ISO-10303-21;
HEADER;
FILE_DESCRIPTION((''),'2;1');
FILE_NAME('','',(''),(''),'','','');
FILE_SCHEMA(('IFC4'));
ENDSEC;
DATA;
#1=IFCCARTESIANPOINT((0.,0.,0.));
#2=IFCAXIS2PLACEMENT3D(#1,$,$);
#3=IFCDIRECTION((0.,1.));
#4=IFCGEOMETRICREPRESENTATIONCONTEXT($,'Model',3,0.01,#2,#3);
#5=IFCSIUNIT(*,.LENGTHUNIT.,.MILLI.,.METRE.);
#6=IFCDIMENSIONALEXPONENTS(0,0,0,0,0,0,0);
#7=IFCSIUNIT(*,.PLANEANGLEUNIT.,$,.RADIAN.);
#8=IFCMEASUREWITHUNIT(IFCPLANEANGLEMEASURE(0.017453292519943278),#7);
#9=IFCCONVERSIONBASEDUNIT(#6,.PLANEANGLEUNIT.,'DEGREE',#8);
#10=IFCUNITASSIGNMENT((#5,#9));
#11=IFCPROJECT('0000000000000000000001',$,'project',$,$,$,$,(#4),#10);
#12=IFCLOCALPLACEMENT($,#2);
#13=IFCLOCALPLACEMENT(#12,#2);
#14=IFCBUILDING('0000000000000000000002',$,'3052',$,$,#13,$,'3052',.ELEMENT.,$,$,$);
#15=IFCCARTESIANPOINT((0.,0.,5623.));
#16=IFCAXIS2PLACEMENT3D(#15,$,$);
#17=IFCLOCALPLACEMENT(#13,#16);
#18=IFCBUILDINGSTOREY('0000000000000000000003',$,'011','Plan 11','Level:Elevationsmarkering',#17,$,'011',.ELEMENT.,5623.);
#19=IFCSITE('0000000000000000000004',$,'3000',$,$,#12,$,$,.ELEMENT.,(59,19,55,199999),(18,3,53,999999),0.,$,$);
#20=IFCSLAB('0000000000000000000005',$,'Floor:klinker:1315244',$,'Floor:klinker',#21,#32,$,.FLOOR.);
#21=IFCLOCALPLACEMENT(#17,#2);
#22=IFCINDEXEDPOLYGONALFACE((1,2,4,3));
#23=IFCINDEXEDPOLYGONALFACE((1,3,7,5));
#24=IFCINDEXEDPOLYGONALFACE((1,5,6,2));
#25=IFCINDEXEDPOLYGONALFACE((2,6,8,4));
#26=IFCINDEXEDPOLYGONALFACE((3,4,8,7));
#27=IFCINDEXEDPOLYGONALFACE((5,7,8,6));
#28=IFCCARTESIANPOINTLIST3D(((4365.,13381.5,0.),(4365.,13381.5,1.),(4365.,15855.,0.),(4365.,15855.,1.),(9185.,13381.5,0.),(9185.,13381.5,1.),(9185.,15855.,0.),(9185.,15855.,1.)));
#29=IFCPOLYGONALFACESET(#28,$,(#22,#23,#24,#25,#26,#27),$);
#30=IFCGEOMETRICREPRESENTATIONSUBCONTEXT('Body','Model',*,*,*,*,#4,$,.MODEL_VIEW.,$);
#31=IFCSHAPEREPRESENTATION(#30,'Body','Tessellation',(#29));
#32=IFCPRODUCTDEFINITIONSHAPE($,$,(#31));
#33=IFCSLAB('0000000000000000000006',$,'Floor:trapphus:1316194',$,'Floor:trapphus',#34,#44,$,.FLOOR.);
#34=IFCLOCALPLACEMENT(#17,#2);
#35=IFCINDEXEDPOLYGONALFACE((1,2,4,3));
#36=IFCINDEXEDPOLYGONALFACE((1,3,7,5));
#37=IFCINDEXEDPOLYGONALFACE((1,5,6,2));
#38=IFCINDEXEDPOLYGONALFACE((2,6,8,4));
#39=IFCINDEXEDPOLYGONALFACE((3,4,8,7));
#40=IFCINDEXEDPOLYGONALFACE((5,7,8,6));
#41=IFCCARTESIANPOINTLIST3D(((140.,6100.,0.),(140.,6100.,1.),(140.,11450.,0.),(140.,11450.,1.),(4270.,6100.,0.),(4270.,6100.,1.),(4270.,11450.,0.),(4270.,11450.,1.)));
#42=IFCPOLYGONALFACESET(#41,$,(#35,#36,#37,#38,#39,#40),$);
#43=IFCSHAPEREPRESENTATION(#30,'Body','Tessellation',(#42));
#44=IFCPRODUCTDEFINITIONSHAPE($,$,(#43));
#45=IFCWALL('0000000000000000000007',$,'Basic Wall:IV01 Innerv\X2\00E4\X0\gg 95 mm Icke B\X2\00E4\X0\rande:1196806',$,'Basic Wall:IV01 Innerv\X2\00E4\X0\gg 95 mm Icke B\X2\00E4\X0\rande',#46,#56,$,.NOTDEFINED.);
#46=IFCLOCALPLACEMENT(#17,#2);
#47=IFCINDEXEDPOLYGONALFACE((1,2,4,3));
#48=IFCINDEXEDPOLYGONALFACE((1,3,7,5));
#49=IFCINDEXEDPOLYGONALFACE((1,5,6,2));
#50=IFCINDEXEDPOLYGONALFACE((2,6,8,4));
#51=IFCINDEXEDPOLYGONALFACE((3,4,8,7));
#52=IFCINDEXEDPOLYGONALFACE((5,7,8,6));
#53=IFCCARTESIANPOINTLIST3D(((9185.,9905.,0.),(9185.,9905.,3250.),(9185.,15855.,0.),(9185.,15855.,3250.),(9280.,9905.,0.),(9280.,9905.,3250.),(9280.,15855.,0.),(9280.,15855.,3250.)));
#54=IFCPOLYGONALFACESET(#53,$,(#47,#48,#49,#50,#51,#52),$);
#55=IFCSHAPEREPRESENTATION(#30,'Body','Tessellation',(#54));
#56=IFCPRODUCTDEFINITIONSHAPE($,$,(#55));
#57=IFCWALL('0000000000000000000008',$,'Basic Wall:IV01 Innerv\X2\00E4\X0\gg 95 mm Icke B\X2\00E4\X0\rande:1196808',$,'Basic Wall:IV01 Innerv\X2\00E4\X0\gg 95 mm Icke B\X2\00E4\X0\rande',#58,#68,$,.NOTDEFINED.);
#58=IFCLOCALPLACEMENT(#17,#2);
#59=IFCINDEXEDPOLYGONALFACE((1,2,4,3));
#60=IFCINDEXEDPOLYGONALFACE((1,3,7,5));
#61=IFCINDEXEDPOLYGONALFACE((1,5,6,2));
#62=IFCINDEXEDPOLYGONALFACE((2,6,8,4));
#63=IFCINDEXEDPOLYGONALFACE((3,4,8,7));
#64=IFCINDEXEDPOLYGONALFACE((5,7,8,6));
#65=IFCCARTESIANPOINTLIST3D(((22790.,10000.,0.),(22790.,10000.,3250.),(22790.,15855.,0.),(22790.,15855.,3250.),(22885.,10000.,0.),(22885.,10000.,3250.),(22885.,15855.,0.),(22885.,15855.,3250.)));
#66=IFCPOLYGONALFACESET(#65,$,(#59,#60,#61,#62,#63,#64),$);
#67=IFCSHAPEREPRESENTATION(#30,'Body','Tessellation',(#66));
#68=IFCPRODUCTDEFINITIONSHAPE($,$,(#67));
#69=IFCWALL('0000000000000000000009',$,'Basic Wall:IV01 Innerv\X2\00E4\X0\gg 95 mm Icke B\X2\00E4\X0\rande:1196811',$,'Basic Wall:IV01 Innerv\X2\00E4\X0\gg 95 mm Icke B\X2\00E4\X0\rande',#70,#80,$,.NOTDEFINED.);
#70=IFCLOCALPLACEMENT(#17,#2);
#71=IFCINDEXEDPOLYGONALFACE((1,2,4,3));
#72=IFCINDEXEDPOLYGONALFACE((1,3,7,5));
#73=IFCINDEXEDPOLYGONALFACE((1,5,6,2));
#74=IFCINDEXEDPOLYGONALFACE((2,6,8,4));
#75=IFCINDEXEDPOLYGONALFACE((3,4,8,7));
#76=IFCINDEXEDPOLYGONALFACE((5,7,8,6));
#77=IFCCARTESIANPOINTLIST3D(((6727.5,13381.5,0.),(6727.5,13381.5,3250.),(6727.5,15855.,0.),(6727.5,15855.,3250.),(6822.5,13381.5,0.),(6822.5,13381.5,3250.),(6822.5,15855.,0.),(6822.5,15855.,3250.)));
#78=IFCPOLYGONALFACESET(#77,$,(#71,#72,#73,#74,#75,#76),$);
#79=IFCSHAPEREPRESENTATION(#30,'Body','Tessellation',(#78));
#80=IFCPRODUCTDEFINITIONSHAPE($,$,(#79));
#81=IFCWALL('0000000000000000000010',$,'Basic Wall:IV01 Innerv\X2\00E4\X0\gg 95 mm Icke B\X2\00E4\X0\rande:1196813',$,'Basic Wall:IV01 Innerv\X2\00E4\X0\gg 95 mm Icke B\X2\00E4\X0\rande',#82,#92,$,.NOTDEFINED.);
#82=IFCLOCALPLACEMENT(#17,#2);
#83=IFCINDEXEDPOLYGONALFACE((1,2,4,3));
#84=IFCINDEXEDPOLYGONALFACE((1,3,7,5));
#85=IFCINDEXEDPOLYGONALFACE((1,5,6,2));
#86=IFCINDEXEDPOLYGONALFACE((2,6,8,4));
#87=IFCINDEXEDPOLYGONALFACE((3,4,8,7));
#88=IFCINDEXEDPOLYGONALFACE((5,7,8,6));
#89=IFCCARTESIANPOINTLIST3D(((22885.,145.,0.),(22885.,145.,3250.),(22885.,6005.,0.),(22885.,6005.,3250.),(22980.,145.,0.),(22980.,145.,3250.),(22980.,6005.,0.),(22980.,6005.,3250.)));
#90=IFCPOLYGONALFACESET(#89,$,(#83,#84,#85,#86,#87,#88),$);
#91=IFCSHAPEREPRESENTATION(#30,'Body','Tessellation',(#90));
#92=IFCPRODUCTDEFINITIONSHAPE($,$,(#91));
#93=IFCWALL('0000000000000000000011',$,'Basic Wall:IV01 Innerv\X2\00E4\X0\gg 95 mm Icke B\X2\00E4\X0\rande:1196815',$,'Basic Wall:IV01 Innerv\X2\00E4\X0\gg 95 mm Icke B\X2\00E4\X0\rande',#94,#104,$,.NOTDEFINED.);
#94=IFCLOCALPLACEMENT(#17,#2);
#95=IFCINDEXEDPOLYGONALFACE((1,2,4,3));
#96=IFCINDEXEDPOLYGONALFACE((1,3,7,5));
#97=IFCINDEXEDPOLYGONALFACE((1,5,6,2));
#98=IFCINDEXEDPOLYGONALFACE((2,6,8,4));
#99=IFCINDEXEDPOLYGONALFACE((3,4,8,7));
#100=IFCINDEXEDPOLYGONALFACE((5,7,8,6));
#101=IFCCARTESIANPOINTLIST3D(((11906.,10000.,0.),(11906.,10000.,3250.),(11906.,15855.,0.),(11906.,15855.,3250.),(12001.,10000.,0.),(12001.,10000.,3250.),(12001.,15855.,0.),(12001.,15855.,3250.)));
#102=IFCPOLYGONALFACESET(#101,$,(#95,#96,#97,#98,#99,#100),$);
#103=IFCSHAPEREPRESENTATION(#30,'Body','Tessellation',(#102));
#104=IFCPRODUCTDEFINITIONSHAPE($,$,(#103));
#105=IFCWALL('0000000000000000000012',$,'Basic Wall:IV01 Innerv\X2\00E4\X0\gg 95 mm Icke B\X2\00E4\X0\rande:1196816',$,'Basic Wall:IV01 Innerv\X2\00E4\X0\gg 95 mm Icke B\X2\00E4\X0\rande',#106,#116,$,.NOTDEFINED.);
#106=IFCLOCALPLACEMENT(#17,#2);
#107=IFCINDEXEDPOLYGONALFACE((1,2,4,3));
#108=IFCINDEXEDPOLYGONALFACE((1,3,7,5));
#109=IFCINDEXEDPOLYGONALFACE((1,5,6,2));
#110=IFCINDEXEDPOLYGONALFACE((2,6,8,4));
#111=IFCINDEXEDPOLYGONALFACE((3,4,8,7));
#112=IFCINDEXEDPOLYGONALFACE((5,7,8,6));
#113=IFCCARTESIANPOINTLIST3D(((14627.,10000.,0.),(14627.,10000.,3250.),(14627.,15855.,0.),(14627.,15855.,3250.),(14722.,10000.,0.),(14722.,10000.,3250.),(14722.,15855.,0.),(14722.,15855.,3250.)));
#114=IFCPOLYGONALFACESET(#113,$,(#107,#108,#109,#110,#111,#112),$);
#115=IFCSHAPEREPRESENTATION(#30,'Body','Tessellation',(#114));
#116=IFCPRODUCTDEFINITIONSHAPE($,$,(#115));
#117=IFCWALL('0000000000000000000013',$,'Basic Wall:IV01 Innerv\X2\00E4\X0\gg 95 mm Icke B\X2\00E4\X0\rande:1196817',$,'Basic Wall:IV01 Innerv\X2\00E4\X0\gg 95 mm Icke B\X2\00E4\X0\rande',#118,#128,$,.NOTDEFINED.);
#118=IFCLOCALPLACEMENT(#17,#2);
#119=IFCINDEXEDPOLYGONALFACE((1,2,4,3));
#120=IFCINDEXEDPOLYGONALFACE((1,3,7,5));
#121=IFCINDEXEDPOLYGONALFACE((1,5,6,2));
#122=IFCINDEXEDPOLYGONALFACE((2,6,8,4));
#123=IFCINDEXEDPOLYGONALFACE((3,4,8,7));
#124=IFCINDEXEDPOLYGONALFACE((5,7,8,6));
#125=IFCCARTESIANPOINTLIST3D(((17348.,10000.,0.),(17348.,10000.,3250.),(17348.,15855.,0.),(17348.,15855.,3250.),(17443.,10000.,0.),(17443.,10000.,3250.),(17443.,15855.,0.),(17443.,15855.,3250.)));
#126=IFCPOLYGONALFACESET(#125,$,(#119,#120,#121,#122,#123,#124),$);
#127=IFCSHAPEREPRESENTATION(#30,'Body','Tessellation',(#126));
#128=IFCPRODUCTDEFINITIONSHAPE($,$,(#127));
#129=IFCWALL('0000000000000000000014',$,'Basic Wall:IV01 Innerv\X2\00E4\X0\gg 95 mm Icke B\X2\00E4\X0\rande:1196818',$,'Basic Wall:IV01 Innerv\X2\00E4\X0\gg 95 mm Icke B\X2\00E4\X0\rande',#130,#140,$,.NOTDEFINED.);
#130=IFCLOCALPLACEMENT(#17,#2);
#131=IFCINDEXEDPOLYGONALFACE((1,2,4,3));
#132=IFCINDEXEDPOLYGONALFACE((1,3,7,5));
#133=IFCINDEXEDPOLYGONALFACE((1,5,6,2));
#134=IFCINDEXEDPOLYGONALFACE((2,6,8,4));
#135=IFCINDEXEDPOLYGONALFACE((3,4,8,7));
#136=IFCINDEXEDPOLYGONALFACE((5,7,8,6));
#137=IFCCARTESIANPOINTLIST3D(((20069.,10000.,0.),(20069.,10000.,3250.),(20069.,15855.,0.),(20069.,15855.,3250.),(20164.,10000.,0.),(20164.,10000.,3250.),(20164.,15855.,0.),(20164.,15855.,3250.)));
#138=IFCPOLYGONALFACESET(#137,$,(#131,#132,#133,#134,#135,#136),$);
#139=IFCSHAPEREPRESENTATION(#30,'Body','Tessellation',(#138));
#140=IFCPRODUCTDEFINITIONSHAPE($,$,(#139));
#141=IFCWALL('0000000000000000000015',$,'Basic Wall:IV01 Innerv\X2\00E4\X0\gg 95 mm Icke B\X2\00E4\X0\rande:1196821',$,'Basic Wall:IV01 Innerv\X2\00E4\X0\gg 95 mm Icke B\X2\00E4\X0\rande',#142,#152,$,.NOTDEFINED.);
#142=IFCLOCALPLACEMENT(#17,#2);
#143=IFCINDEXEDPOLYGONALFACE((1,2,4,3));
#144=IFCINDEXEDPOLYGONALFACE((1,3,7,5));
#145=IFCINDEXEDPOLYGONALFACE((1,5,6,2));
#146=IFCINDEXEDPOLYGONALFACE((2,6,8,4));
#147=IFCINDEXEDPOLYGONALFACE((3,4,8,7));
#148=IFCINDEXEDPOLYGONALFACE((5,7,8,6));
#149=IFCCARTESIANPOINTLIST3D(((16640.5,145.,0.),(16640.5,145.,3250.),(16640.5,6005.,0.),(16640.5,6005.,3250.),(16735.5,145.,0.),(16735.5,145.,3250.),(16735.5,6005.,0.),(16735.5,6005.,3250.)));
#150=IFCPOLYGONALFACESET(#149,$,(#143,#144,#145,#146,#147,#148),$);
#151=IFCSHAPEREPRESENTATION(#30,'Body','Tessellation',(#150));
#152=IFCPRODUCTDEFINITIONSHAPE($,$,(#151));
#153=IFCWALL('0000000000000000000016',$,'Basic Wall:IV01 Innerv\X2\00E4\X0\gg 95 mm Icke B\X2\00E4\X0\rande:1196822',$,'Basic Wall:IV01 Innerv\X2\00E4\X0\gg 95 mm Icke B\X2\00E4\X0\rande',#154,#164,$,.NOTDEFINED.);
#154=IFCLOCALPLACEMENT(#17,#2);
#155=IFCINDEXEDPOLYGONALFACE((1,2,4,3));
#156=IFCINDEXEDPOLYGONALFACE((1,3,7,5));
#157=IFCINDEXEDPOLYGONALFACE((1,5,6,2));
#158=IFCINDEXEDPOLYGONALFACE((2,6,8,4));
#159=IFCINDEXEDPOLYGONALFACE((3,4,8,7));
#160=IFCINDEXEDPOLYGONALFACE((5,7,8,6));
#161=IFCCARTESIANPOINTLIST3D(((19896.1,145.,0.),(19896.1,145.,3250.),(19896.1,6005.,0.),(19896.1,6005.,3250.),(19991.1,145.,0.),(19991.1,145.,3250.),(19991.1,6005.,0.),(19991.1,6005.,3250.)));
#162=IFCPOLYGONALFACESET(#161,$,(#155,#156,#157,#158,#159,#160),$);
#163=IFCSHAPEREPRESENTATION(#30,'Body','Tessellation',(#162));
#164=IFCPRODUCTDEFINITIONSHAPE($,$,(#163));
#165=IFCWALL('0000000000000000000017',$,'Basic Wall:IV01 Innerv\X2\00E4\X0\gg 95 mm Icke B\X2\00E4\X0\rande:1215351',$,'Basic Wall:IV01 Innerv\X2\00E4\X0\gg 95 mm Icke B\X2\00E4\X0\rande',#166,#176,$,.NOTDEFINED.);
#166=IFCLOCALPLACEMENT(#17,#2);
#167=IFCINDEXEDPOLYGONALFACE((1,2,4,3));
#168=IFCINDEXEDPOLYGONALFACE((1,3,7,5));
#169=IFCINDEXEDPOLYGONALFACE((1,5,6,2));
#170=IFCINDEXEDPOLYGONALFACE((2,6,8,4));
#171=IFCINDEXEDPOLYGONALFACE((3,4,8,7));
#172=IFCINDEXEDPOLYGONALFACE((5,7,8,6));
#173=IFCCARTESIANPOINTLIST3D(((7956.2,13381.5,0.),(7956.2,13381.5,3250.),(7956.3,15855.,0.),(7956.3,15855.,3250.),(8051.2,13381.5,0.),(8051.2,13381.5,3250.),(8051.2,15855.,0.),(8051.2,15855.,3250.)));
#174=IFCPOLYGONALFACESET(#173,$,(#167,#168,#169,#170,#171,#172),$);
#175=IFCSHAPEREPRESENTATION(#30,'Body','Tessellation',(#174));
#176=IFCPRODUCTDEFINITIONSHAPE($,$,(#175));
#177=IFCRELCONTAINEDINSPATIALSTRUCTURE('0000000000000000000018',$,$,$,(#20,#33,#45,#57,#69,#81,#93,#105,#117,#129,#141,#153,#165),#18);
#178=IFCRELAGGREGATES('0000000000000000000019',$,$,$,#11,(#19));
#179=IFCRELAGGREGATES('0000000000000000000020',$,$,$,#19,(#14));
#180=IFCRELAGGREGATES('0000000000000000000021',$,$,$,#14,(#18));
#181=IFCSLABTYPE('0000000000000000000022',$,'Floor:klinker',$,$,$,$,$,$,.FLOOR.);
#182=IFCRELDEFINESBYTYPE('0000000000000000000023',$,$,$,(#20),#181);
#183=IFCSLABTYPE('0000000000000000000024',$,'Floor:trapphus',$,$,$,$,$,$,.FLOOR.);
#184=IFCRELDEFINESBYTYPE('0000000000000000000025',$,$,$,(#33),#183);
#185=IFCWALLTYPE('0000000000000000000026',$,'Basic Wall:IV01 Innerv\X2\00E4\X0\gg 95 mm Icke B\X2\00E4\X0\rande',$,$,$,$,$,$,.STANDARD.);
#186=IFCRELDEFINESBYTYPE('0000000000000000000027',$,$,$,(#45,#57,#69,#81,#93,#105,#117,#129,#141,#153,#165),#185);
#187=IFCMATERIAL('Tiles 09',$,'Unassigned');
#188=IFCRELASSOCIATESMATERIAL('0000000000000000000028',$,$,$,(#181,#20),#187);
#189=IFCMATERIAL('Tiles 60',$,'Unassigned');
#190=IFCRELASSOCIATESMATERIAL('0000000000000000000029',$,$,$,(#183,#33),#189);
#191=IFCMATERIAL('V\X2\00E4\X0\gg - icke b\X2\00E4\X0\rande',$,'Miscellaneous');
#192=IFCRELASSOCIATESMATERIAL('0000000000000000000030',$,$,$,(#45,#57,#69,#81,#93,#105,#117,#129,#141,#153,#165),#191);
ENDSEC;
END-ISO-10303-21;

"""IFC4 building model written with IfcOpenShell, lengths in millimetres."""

from ifc_helpers import new_model, entity, si_unit, converted_unit, direction, frame, origin, place, context, subcontext, project, spatial, indexed_curve, outline, extrude, material, type_object, element, save


model = new_model("IFC4")

# Units and contexts
model_context = context("Model", 3, precision=0.01, world=origin(), true_north=direction((0.0, 1.0)))
body_context = subcontext(model_context, "Body", "Model", "MODEL_VIEW")
ifc_project = project(units=[si_unit("LENGTHUNIT", "METRE", prefix="MILLI"), converted_unit("PLANEANGLEUNIT", "DEGREE", entity("IfcPlaneAngleMeasure", 0.017453292519943278), si_unit("PLANEANGLEUNIT", "RADIAN"), dimensions=[0, 0, 0, 0, 0, 0, 0])], contexts=[model_context])

# Site, building, storey
site_placement = place(None, origin())
site = spatial("IfcSite", under=ifc_project, at=site_placement, Name="3000", CompositionType="ELEMENT", RefLatitude=(59, 19, 55, 199999), RefLongitude=(18, 3, 53, 999999), RefElevation=0.0)
building_placement = place(site_placement, origin())
building = spatial("IfcBuilding", under=site, at=building_placement, Name="3052", LongName="3052", CompositionType="ELEMENT")
storey_placement = place(building_placement, frame((0.0, 0.0, 5623.0)))
storey = spatial("IfcBuildingStorey", under=building, at=storey_placement, Name="011", Description="Plan 11", ObjectType="Level:Elevationsmarkering", LongName="011", CompositionType="ELEMENT", Elevation=5623.0)

# Slabs
ifc_material_1 = material(Name="Tiles 09", Category="Unassigned")
slab_type_1 = type_object("IfcSlabType", Name="Floor:klinker", PredefinedType="FLOOR", material=ifc_material_1)
slab_1_placement = place(storey_placement, origin())
element("IfcSlab", 1, at=slab_1_placement, inside=storey, type_object=slab_type_1, material=ifc_material_1, Name="Floor:klinker:1315244", ObjectType="Floor:klinker", PredefinedType="FLOOR", context=body_context, shape_type="SweptSolid", body=[
    extrude(outline(indexed_curve([(-1236.8, -2410.0), (1236.8, -2410.0), (1236.8, 2410.0), (-1236.8, 2410.0), (-1236.8, -2410.0)], self_intersect=False)), frame((6775.0, 14618.3, 1.0), z_axis=(0.0, 0.0, -1.0), x_axis=(0.0, 1.0, 0.0)), (0.0, 0.0, 1.0), 1.0),
])
ifc_material_2 = material(Name="Tiles 60", Category="Unassigned")
slab_type_2 = type_object("IfcSlabType", Name="Floor:trapphus", PredefinedType="FLOOR", material=ifc_material_2)
slab_2_placement = place(storey_placement, origin())
element("IfcSlab", 2, at=slab_2_placement, inside=storey, type_object=slab_type_2, material=ifc_material_2, Name="Floor:trapphus:1316194", ObjectType="Floor:trapphus", PredefinedType="FLOOR", context=body_context, shape_type="SweptSolid", body=[
    extrude(outline(indexed_curve([(-2675.0, -2065.0), (2675.0, -2065.0), (2675.0, 2065.0), (-2675.0, 2065.0), (-2675.0, -2065.0)], self_intersect=False)), frame((2205.0, 8775.0, 1.0), z_axis=(0.0, 0.0, -1.0), x_axis=(0.0, 1.0, 0.0)), (0.0, 0.0, 1.0), 1.0),
])

# Walls
ifc_material_3 = material(Name="Vägg - icke bärande", Category="Miscellaneous")
wall_type_1 = type_object("IfcWallType", Name="Basic Wall:IV01 Innervägg 95 mm Icke Bärande", PredefinedType="STANDARD")
wall_1_placement = place(storey_placement, frame((9232.5, 15855.0, 0.0), z_axis=(0.0, 0.0, 1.0), x_axis=(0.0, -1.0, 0.0)))
element("IfcWall", 3, at=wall_1_placement, inside=storey, type_object=wall_type_1, material=ifc_material_3, Name="Basic Wall:IV01 Innervägg 95 mm Icke Bärande:1196806", ObjectType="Basic Wall:IV01 Innervägg 95 mm Icke Bärande", PredefinedType="NOTDEFINED", context=body_context, shape_type="SweptSolid", body=[
    extrude(outline(indexed_curve([(5950.0, 47.5), (0.0, 47.5), (0.0, -47.5), (5950.0, -47.5), (5950.0, 47.5)], self_intersect=False)), origin(), (0.0, 0.0, 1.0), 3250.0),
])
wall_2_placement = place(storey_placement, frame((22837.5, 10000.0, 0.0), z_axis=(0.0, 0.0, 1.0), x_axis=(0.0, 1.0, 0.0)))
element("IfcWall", 4, at=wall_2_placement, inside=storey, type_object=wall_type_1, material=ifc_material_3, Name="Basic Wall:IV01 Innervägg 95 mm Icke Bärande:1196808", ObjectType="Basic Wall:IV01 Innervägg 95 mm Icke Bärande", PredefinedType="NOTDEFINED", context=body_context, shape_type="SweptSolid", body=[
    extrude(outline(indexed_curve([(5855.0, 47.5), (0.0, 47.5), (0.0, -47.5), (5855.0, -47.5), (5855.0, 47.5)], self_intersect=False)), origin(), (0.0, 0.0, 1.0), 3250.0),
])
wall_3_placement = place(storey_placement, frame((6775.0, 13381.5, 0.0), z_axis=(0.0, 0.0, 1.0), x_axis=(0.0, 1.0, 0.0)))
element("IfcWall", 5, at=wall_3_placement, inside=storey, type_object=wall_type_1, material=ifc_material_3, Name="Basic Wall:IV01 Innervägg 95 mm Icke Bärande:1196811", ObjectType="Basic Wall:IV01 Innervägg 95 mm Icke Bärande", PredefinedType="NOTDEFINED", context=body_context, shape_type="SweptSolid", body=[
    extrude(outline(indexed_curve([(2473.5, 47.5), (0.0, 47.5), (0.0, -47.5), (2473.5, -47.5), (2473.5, 47.5)], self_intersect=False)), origin(), (0.0, 0.0, 1.0), 3250.0),
])
wall_4_placement = place(storey_placement, frame((22932.5, 6005.0, 0.0), z_axis=(0.0, 0.0, 1.0), x_axis=(0.0, -1.0, 0.0)))
element("IfcWall", 6, at=wall_4_placement, inside=storey, type_object=wall_type_1, material=ifc_material_3, Name="Basic Wall:IV01 Innervägg 95 mm Icke Bärande:1196813", ObjectType="Basic Wall:IV01 Innervägg 95 mm Icke Bärande", PredefinedType="NOTDEFINED", context=body_context, shape_type="SweptSolid", body=[
    extrude(outline(indexed_curve([(5860.0, 47.5), (0.0, 47.5), (0.0, -47.5), (5860.0, -47.5), (5860.0, 47.5)], self_intersect=False)), origin(), (0.0, 0.0, 1.0), 3250.0),
])
wall_5_placement = place(storey_placement, frame((11953.5, 15855.0, 0.0), z_axis=(0.0, 0.0, 1.0), x_axis=(0.0, -1.0, 0.0)))
element("IfcWall", 7, at=wall_5_placement, inside=storey, type_object=wall_type_1, material=ifc_material_3, Name="Basic Wall:IV01 Innervägg 95 mm Icke Bärande:1196815", ObjectType="Basic Wall:IV01 Innervägg 95 mm Icke Bärande", PredefinedType="NOTDEFINED", context=body_context, shape_type="SweptSolid", body=[
    extrude(outline(indexed_curve([(5855.0, 47.5), (0.0, 47.5), (0.0, -47.5), (5855.0, -47.5), (5855.0, 47.5)], self_intersect=False)), origin(), (0.0, 0.0, 1.0), 3250.0),
])
wall_6_placement = place(storey_placement, frame((14674.5, 15855.0, 0.0), z_axis=(0.0, 0.0, 1.0), x_axis=(0.0, -1.0, 0.0)))
element("IfcWall", 8, at=wall_6_placement, inside=storey, type_object=wall_type_1, material=ifc_material_3, Name="Basic Wall:IV01 Innervägg 95 mm Icke Bärande:1196816", ObjectType="Basic Wall:IV01 Innervägg 95 mm Icke Bärande", PredefinedType="NOTDEFINED", context=body_context, shape_type="SweptSolid", body=[
    extrude(outline(indexed_curve([(5855.0, 47.5), (0.0, 47.5), (0.0, -47.5), (5855.0, -47.5), (5855.0, 47.5)], self_intersect=False)), origin(), (0.0, 0.0, 1.0), 3250.0),
])
wall_7_placement = place(storey_placement, frame((17395.5, 15855.0, 0.0), z_axis=(0.0, 0.0, 1.0), x_axis=(0.0, -1.0, 0.0)))
element("IfcWall", 9, at=wall_7_placement, inside=storey, type_object=wall_type_1, material=ifc_material_3, Name="Basic Wall:IV01 Innervägg 95 mm Icke Bärande:1196817", ObjectType="Basic Wall:IV01 Innervägg 95 mm Icke Bärande", PredefinedType="NOTDEFINED", context=body_context, shape_type="SweptSolid", body=[
    extrude(outline(indexed_curve([(5855.0, 47.5), (0.0, 47.5), (0.0, -47.5), (5855.0, -47.5), (5855.0, 47.5)], self_intersect=False)), origin(), (0.0, 0.0, 1.0), 3250.0),
])
wall_8_placement = place(storey_placement, frame((20116.5, 15855.0, 0.0), z_axis=(0.0, 0.0, 1.0), x_axis=(0.0, -1.0, 0.0)))
element("IfcWall", 10, at=wall_8_placement, inside=storey, type_object=wall_type_1, material=ifc_material_3, Name="Basic Wall:IV01 Innervägg 95 mm Icke Bärande:1196818", ObjectType="Basic Wall:IV01 Innervägg 95 mm Icke Bärande", PredefinedType="NOTDEFINED", context=body_context, shape_type="SweptSolid", body=[
    extrude(outline(indexed_curve([(5855.0, 47.5), (0.0, 47.5), (0.0, -47.5), (5855.0, -47.5), (5855.0, 47.5)], self_intersect=False)), origin(), (0.0, 0.0, 1.0), 3250.0),
])
wall_9_placement = place(storey_placement, frame((16688.0, 6005.0, 0.0), z_axis=(0.0, 0.0, 1.0), x_axis=(0.0, -1.0, 0.0)))
element("IfcWall", 11, at=wall_9_placement, inside=storey, type_object=wall_type_1, material=ifc_material_3, Name="Basic Wall:IV01 Innervägg 95 mm Icke Bärande:1196821", ObjectType="Basic Wall:IV01 Innervägg 95 mm Icke Bärande", PredefinedType="NOTDEFINED", context=body_context, shape_type="SweptSolid", body=[
    extrude(outline(indexed_curve([(5860.0, 47.5), (0.0, 47.5), (0.0, -47.5), (5860.0, -47.5), (5860.0, 47.5)], self_intersect=False)), origin(), (0.0, 0.0, 1.0), 3250.0),
])
wall_10_placement = place(storey_placement, frame((19943.6, 6005.0, 0.0), z_axis=(0.0, 0.0, 1.0), x_axis=(0.0, -1.0, 0.0)))
element("IfcWall", 12, at=wall_10_placement, inside=storey, type_object=wall_type_1, material=ifc_material_3, Name="Basic Wall:IV01 Innervägg 95 mm Icke Bärande:1196822", ObjectType="Basic Wall:IV01 Innervägg 95 mm Icke Bärande", PredefinedType="NOTDEFINED", context=body_context, shape_type="SweptSolid", body=[
    extrude(outline(indexed_curve([(5860.0, 47.5), (0.0, 47.5), (0.0, -47.5), (5860.0, -47.5), (5860.0, 47.5)], self_intersect=False)), origin(), (0.0, 0.0, 1.0), 3250.0),
])
wall_11_placement = place(storey_placement, frame((8003.8, 13381.5, 0.0), z_axis=(0.0, 0.0, 1.0), x_axis=(0.0, 1.0, 0.0)))
element("IfcWall", 13, at=wall_11_placement, inside=storey, type_object=wall_type_1, material=ifc_material_3, Name="Basic Wall:IV01 Innervägg 95 mm Icke Bärande:1215351", ObjectType="Basic Wall:IV01 Innervägg 95 mm Icke Bärande", PredefinedType="NOTDEFINED", context=body_context, shape_type="SweptSolid", body=[
    extrude(outline(indexed_curve([(2473.5, 47.5), (0.0, 47.5), (0.0, -47.5), (2473.5, -47.5), (2473.5, 47.5)], self_intersect=False)), origin(), (0.0, 0.0, 1.0), 3250.0),
])

save(model, "model.ifc")
